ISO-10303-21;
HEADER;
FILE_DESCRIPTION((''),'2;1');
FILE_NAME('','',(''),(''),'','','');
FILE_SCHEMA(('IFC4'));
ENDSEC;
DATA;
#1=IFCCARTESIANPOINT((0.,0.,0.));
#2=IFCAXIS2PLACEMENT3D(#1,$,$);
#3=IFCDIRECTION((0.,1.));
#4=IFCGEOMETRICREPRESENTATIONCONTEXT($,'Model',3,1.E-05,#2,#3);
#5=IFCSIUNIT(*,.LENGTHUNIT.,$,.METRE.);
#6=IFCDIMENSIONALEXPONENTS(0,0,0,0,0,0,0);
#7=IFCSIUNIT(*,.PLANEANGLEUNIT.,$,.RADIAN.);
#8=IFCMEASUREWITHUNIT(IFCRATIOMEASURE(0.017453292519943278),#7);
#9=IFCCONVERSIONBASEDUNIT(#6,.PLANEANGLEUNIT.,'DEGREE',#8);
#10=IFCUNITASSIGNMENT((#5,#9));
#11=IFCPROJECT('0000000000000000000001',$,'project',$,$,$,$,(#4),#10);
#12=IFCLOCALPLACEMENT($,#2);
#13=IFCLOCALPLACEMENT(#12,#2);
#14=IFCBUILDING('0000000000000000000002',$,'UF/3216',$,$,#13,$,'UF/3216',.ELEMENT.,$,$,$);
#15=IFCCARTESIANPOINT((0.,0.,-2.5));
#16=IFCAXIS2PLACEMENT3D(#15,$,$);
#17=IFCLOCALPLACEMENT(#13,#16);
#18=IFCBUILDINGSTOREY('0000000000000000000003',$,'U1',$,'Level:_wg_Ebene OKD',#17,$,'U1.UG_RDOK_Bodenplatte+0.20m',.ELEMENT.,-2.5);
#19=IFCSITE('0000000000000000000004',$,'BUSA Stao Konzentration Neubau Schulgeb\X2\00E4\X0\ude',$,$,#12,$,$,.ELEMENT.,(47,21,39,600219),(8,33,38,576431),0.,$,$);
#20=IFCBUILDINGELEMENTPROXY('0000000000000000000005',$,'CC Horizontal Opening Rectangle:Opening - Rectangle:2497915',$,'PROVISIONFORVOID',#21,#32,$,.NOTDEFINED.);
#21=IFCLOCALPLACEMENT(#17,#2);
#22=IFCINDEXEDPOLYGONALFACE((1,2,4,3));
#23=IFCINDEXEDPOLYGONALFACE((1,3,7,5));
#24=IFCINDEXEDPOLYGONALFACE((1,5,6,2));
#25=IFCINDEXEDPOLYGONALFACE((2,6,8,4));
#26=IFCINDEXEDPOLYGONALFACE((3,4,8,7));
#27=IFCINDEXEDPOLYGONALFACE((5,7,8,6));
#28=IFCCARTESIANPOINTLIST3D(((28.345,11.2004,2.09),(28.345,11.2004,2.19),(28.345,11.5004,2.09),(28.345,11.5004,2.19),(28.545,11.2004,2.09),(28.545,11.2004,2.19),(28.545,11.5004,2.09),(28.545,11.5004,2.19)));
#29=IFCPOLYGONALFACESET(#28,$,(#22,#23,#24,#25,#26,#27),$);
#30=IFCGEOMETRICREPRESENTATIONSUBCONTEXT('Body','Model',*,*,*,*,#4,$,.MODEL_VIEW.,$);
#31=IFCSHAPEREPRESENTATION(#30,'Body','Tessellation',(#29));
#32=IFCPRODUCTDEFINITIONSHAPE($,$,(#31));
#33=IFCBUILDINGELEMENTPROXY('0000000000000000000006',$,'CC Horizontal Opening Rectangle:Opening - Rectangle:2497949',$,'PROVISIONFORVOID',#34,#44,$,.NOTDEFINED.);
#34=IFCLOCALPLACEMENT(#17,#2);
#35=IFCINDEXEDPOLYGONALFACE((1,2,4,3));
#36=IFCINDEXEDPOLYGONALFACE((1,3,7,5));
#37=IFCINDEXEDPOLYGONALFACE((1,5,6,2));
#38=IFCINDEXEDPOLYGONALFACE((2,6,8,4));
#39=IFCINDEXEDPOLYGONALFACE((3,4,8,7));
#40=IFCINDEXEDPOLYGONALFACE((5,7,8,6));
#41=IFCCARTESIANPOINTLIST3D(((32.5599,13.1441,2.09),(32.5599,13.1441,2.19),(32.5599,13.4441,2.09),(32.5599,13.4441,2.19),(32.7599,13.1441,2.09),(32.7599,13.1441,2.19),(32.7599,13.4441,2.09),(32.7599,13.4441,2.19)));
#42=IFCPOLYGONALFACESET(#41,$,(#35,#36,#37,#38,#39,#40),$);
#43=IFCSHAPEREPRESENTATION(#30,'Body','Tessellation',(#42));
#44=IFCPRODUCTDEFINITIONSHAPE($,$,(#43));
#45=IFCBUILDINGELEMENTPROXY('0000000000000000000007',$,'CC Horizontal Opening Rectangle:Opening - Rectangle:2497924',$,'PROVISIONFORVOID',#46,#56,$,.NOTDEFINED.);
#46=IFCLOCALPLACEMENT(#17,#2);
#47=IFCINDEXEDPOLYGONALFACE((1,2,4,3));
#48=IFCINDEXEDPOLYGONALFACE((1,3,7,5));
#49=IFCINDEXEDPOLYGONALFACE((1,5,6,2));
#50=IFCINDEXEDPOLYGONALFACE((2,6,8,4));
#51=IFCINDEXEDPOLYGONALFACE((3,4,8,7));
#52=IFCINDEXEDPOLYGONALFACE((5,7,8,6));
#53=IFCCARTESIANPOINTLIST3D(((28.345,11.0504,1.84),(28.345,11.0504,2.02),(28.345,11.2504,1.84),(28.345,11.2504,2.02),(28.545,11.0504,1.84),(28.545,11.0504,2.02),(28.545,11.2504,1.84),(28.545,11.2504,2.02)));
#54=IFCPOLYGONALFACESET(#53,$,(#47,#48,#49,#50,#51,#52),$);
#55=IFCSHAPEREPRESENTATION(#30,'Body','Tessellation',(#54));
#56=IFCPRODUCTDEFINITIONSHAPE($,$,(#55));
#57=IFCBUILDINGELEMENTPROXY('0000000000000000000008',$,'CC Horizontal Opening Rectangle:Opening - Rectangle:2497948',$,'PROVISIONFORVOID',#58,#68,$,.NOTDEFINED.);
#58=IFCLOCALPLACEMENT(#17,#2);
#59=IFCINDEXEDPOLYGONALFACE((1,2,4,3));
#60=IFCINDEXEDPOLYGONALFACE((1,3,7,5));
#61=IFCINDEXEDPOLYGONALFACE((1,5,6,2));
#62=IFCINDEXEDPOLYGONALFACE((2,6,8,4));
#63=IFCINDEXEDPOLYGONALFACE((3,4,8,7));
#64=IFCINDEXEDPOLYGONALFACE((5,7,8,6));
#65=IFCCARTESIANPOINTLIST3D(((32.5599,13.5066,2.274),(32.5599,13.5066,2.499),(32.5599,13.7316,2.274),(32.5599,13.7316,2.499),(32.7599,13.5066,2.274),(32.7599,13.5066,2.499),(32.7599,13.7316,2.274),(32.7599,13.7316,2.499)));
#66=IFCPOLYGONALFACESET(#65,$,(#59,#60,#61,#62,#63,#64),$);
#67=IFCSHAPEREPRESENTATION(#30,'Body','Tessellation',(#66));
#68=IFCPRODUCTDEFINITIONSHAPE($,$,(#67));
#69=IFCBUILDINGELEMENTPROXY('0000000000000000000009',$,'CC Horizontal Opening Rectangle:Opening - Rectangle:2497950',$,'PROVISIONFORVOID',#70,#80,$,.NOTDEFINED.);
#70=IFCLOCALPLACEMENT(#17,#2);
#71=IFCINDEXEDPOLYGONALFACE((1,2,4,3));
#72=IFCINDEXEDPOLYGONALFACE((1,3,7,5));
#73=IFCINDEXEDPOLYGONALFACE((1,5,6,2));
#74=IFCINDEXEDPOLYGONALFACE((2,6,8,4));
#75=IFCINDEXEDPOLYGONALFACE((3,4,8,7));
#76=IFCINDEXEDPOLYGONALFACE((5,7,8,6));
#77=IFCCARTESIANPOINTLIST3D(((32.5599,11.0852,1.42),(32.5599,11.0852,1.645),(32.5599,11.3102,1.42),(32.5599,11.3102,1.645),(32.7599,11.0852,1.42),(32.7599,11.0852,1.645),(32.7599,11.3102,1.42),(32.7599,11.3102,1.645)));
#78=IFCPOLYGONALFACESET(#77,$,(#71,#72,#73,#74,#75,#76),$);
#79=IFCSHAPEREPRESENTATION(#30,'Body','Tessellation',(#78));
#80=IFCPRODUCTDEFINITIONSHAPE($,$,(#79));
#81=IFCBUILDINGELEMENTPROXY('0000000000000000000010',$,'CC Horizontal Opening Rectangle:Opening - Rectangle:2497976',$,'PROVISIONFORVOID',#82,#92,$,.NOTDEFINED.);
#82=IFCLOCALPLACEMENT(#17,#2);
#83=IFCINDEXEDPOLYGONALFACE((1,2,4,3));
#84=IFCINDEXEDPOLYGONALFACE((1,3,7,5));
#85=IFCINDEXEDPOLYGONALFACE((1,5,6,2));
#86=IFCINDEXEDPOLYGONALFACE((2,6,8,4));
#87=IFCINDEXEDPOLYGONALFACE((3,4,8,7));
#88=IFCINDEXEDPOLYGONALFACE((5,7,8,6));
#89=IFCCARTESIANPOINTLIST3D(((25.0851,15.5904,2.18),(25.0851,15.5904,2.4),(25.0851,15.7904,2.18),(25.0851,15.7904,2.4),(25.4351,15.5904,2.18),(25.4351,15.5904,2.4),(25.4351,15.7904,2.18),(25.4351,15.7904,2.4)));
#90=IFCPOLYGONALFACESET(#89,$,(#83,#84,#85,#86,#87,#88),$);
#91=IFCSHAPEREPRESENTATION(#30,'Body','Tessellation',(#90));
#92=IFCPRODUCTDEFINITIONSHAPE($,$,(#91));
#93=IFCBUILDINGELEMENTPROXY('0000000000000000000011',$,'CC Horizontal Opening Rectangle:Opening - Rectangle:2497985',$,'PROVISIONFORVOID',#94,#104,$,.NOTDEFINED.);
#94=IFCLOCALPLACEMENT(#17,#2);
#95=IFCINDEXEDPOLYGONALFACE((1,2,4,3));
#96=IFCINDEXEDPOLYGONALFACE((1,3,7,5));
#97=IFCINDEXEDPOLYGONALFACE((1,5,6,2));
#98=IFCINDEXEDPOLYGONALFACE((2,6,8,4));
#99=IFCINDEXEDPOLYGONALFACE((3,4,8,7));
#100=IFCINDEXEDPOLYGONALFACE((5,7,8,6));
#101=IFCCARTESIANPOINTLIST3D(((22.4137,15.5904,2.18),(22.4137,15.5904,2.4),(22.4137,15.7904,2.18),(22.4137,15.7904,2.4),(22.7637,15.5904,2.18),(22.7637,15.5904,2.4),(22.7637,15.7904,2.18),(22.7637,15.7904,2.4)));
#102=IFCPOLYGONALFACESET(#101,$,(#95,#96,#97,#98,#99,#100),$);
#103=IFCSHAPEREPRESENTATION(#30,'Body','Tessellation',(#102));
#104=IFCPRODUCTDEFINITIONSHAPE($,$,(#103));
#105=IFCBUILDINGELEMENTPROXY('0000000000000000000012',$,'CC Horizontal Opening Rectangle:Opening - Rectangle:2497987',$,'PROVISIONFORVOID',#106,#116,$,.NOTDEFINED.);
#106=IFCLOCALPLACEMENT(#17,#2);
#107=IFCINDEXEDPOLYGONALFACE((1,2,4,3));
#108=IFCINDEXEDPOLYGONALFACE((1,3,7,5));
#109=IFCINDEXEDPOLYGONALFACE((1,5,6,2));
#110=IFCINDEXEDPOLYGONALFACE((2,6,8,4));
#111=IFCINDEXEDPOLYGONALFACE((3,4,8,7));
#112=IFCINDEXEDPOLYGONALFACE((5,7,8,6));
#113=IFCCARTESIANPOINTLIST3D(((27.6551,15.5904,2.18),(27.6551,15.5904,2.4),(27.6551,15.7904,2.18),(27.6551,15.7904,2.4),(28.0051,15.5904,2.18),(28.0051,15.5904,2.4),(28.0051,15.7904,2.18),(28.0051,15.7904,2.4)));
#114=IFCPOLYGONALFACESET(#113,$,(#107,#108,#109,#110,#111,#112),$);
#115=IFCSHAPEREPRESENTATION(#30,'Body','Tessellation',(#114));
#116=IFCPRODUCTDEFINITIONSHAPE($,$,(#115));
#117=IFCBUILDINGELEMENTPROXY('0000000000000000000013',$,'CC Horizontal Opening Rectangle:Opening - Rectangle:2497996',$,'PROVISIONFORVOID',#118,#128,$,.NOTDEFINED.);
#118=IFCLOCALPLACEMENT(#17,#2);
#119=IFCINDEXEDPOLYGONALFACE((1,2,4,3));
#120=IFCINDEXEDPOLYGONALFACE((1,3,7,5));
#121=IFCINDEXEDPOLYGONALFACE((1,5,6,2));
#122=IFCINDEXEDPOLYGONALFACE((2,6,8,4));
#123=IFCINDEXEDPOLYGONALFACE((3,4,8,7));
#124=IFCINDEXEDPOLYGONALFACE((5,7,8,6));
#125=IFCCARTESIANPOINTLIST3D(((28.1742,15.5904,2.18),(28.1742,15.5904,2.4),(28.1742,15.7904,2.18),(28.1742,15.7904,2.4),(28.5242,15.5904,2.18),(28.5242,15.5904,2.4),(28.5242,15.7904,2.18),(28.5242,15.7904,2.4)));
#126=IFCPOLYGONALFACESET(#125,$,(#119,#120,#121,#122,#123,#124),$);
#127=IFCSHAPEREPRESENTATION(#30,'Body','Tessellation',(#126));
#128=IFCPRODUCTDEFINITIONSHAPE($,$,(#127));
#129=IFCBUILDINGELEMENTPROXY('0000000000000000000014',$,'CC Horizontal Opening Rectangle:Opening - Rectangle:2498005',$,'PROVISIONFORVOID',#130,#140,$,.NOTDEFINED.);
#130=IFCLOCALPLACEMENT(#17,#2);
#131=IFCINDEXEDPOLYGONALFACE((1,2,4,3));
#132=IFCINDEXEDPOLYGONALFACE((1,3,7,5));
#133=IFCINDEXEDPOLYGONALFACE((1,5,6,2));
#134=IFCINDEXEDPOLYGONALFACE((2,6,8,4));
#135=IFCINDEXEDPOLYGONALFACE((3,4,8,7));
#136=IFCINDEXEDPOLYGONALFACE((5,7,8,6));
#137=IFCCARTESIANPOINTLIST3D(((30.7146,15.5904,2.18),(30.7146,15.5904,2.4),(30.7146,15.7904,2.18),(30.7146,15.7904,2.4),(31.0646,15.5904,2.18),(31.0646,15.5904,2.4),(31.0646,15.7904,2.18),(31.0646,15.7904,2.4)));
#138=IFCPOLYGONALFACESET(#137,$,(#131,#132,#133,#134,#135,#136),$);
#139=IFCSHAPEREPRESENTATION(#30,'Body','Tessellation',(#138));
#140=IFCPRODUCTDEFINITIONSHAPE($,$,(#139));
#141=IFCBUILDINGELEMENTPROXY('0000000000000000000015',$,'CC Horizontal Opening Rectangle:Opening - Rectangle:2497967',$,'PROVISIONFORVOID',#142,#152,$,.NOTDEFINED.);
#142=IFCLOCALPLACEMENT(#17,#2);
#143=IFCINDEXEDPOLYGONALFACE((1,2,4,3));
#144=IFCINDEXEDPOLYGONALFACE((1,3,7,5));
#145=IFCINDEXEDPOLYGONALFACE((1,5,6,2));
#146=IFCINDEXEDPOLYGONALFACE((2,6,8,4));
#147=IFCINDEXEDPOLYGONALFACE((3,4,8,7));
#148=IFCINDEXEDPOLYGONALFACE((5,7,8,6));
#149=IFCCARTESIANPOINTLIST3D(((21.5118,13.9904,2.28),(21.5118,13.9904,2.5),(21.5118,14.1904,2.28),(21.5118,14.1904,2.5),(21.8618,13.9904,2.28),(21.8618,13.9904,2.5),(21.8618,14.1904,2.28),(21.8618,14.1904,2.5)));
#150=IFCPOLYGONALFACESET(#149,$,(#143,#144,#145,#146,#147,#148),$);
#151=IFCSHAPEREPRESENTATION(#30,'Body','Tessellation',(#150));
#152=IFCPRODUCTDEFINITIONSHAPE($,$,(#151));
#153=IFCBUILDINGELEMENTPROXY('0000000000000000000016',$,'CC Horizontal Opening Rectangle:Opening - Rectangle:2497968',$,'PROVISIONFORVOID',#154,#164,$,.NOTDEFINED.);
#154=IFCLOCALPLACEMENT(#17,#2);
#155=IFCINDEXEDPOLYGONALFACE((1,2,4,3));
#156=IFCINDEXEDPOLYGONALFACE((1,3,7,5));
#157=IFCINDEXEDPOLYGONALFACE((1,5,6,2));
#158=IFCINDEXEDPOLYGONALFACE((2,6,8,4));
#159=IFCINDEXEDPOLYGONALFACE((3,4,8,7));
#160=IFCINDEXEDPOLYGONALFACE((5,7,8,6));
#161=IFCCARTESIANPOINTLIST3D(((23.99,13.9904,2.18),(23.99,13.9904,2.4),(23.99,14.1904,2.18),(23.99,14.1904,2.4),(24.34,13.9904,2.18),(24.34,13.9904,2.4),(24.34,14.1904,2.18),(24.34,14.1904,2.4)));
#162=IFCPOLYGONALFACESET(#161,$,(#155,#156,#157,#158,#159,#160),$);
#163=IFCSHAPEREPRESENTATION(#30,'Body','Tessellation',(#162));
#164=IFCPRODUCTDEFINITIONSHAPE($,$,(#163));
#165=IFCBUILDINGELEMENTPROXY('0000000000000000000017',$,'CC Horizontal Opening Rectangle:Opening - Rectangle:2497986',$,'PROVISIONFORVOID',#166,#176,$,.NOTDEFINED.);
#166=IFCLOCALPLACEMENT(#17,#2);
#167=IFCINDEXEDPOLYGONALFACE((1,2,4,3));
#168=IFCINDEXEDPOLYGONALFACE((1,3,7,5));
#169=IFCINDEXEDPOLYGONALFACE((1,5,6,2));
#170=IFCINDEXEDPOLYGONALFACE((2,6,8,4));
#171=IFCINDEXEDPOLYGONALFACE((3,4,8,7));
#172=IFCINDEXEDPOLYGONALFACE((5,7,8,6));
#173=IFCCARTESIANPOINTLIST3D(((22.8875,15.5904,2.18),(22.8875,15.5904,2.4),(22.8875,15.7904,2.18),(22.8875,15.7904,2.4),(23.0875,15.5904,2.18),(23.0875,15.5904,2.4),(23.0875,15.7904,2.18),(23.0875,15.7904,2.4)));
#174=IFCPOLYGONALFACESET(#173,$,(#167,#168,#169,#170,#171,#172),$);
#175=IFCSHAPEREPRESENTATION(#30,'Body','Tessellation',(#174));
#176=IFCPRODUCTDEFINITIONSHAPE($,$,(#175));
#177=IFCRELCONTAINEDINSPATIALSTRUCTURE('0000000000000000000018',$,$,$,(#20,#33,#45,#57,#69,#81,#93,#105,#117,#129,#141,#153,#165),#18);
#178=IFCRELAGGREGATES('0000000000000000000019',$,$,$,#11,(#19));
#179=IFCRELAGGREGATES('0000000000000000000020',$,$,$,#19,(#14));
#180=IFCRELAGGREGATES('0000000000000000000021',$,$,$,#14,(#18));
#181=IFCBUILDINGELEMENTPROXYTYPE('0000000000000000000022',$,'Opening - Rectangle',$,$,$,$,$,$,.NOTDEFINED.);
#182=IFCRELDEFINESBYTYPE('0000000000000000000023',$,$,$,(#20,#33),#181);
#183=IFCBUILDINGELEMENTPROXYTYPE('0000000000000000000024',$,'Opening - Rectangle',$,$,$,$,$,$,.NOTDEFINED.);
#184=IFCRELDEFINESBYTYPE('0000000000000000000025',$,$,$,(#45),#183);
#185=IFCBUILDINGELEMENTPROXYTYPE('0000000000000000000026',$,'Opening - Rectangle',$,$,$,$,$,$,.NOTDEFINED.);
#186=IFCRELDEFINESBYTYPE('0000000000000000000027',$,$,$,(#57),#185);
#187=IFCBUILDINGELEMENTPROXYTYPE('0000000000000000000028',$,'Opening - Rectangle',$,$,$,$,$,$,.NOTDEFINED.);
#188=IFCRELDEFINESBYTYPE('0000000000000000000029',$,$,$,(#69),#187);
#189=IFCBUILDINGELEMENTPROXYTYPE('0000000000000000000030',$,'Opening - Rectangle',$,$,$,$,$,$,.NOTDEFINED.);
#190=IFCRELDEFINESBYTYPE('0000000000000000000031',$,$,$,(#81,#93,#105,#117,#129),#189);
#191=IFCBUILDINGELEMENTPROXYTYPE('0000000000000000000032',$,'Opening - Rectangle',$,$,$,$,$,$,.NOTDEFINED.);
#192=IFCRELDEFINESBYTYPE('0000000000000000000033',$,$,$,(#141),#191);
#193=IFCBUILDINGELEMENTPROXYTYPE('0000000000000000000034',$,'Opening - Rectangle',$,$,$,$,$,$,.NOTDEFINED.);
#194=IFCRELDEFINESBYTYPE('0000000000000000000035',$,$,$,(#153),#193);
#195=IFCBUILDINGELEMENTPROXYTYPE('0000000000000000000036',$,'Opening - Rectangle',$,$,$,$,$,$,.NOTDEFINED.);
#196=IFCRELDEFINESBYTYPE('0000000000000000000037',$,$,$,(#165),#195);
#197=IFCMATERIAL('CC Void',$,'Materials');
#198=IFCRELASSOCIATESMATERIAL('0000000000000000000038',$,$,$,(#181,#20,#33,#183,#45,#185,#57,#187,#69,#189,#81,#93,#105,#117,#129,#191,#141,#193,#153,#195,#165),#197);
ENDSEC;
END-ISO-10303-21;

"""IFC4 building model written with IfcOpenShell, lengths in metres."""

from ifc_helpers import new_model, entity, si_unit, converted_unit, direction, frame, origin, place, context, subcontext, project, spatial, indexed_curve, outline, extrude, source, transform, mapped, material, type_object, type_shapes, element, save


model = new_model("IFC4")

# Units and contexts
model_context = context("Model", 3, precision=1e-05, world=origin(), true_north=direction((0.0, 1.0)))
body_context = subcontext(model_context, "Body", "Model", "MODEL_VIEW")
ifc_project = project(units=[si_unit("LENGTHUNIT", "METRE"), converted_unit("PLANEANGLEUNIT", "DEGREE", entity("IfcRatioMeasure", 0.017453292519943278), si_unit("PLANEANGLEUNIT", "RADIAN"), dimensions=[0, 0, 0, 0, 0, 0, 0])], contexts=[model_context])

# Site, building, storey
site_placement = place(None, origin())
site = spatial("IfcSite", under=ifc_project, at=site_placement, Name="BUSA Stao Konzentration Neubau Schulgebäude", CompositionType="ELEMENT", RefLatitude=(47, 21, 39, 600219), RefLongitude=(8, 33, 38, 576431), RefElevation=0.0)
building_placement = place(site_placement, origin())
building = spatial("IfcBuilding", under=site, at=building_placement, Name="UF/3216", LongName="UF/3216", CompositionType="ELEMENT")
storey_placement = place(building_placement, frame((0.0, 0.0, -2.5)))
storey = spatial("IfcBuildingStorey", under=building, at=storey_placement, Name="U1", ObjectType="Level:_wg_Ebene OKD", LongName="U1.UG_RDOK_Bodenplatte+0.20m", CompositionType="ELEMENT", Elevation=-2.5)

# Building element proxies
ifc_material_1 = material(Name="CC Void", Category="Materials")
building_element_proxy_type_1 = type_object("IfcBuildingElementProxyType", Name="Opening - Rectangle", PredefinedType="NOTDEFINED", material=ifc_material_1)
shared_shape_1 = source(origin(), body_context, "Body", "SweptSolid", [
    extrude(outline(indexed_curve([(-0.1, -0.15), (0.1, -0.15), (0.1, 0.15), (-0.1, 0.15), (-0.1, -0.15)], self_intersect=False)), frame((0.0, 0.0, -0.41), z_axis=(0.0, 0.0, 1.0), x_axis=(0.0, -1.0, 0.0)), (0.0, 0.0, 1.0), 0.1),
])
type_shapes(building_element_proxy_type_1, [shared_shape_1])
for number, where, z_axis, x_axis, name in (
    (1, (28.445, 11.3504, 2.5), (0.0, 0.0, 1.0), (0.0, 1.0, 0.0), "CC Horizontal Opening Rectangle:Opening - Rectangle:2497915"),
    (2, (32.6599, 13.2941, 2.5), (0.0, 0.0, 1.0), (0.0, 1.0, 0.0), "CC Horizontal Opening Rectangle:Opening - Rectangle:2497949"),
):
    element("IfcBuildingElementProxy", number, at=place(storey_placement, frame(where, z_axis=z_axis, x_axis=x_axis)), inside=storey, type_object=building_element_proxy_type_1, material=ifc_material_1, Name=name, ObjectType="PROVISIONFORVOID", PredefinedType="NOTDEFINED", context=body_context, shape_type="MappedRepresentation", body=[
        mapped(shared_shape_1, transform((0.0, 0.0, 0.0), scale=1.0)),
    ])
building_element_proxy_type_2 = type_object("IfcBuildingElementProxyType", Name="Opening - Rectangle", PredefinedType="NOTDEFINED", material=ifc_material_1)
shared_shape_2 = source(origin(), body_context, "Body", "SweptSolid", [
    extrude(outline(indexed_curve([(-0.1, -0.1), (0.1, -0.1), (0.1, 0.1), (-0.1, 0.1), (-0.1, -0.1)], self_intersect=False)), frame((0.0, 0.0, -0.66), z_axis=(0.0, 0.0, 1.0), x_axis=(0.0, -1.0, 0.0)), (0.0, 0.0, 1.0), 0.18),
])
type_shapes(building_element_proxy_type_2, [shared_shape_2])
proxy_1_placement = place(storey_placement, frame((28.445, 11.1504, 2.5), z_axis=(0.0, 0.0, 1.0), x_axis=(0.0, 1.0, 0.0)))
element("IfcBuildingElementProxy", 3, at=proxy_1_placement, inside=storey, type_object=building_element_proxy_type_2, material=ifc_material_1, Name="CC Horizontal Opening Rectangle:Opening - Rectangle:2497924", ObjectType="PROVISIONFORVOID", PredefinedType="NOTDEFINED", context=body_context, shape_type="MappedRepresentation", body=[
    mapped(shared_shape_2, transform((0.0, 0.0, 0.0), scale=1.0)),
])
building_element_proxy_type_3 = type_object("IfcBuildingElementProxyType", Name="Opening - Rectangle", PredefinedType="NOTDEFINED", material=ifc_material_1)
shared_shape_3 = source(origin(), body_context, "Body", "SweptSolid", [
    extrude(outline(indexed_curve([(-0.1, -0.1125), (0.1, -0.1125), (0.1, 0.1125), (-0.1, 0.1125), (-0.1, -0.1125)], self_intersect=False)), frame((0.0, 0.0, -0.226), z_axis=(0.0, 0.0, 1.0), x_axis=(0.0, -1.0, 0.0)), (0.0, 0.0, 1.0), 0.225),
])
type_shapes(building_element_proxy_type_3, [shared_shape_3])
proxy_2_placement = place(storey_placement, frame((32.6599, 13.6191, 2.5), z_axis=(0.0, 0.0, 1.0), x_axis=(0.0, 1.0, 0.0)))
element("IfcBuildingElementProxy", 4, at=proxy_2_placement, inside=storey, type_object=building_element_proxy_type_3, material=ifc_material_1, Name="CC Horizontal Opening Rectangle:Opening - Rectangle:2497948", ObjectType="PROVISIONFORVOID", PredefinedType="NOTDEFINED", context=body_context, shape_type="MappedRepresentation", body=[
    mapped(shared_shape_3, transform((0.0, 0.0, 0.0), scale=1.0)),
])
building_element_proxy_type_4 = type_object("IfcBuildingElementProxyType", Name="Opening - Rectangle", PredefinedType="NOTDEFINED", material=ifc_material_1)
shared_shape_4 = source(origin(), body_context, "Body", "SweptSolid", [
    extrude(outline(indexed_curve([(-0.1, -0.1125), (0.1, -0.1125), (0.1, 0.1125), (-0.1, 0.1125), (-0.1, -0.1125)], self_intersect=False)), frame((0.0, 0.0, -1.08), z_axis=(0.0, 0.0, 1.0), x_axis=(0.0, -1.0, 0.0)), (0.0, 0.0, 1.0), 0.225),
])
type_shapes(building_element_proxy_type_4, [shared_shape_4])
proxy_3_placement = place(storey_placement, frame((32.6599, 11.1977, 2.5), z_axis=(0.0, 0.0, 1.0), x_axis=(0.0, 1.0, 0.0)))
element("IfcBuildingElementProxy", 5, at=proxy_3_placement, inside=storey, type_object=building_element_proxy_type_4, material=ifc_material_1, Name="CC Horizontal Opening Rectangle:Opening - Rectangle:2497950", ObjectType="PROVISIONFORVOID", PredefinedType="NOTDEFINED", context=body_context, shape_type="MappedRepresentation", body=[
    mapped(shared_shape_4, transform((0.0, 0.0, 0.0), scale=1.0)),
])
building_element_proxy_type_5 = type_object("IfcBuildingElementProxyType", Name="Opening - Rectangle", PredefinedType="NOTDEFINED", material=ifc_material_1)
shared_shape_5 = source(origin(), body_context, "Body", "SweptSolid", [
    extrude(outline(indexed_curve([(-0.1, -0.175), (0.1, -0.175), (0.1, 0.175), (-0.1, 0.175), (-0.1, -0.175)], self_intersect=False)), frame((0.0, 0.0, -0.32), z_axis=(0.0, 0.0, 1.0), x_axis=(0.0, -1.0, 0.0)), (0.0, 0.0, 1.0), 0.22),
])
type_shapes(building_element_proxy_type_5, [shared_shape_5])
for number, where, name in (
    (6, (25.2601, 15.6904, 2.5), "CC Horizontal Opening Rectangle:Opening - Rectangle:2497976"),
    (7, (22.5887, 15.6904, 2.5), "CC Horizontal Opening Rectangle:Opening - Rectangle:2497985"),
    (8, (27.8301, 15.6904, 2.5), "CC Horizontal Opening Rectangle:Opening - Rectangle:2497987"),
    (9, (28.3492, 15.6904, 2.5), "CC Horizontal Opening Rectangle:Opening - Rectangle:2497996"),
    (10, (30.8896, 15.6904, 2.5), "CC Horizontal Opening Rectangle:Opening - Rectangle:2498005"),
):
    element("IfcBuildingElementProxy", number, at=place(storey_placement, frame(where)), inside=storey, type_object=building_element_proxy_type_5, material=ifc_material_1, Name=name, ObjectType="PROVISIONFORVOID", PredefinedType="NOTDEFINED", context=body_context, shape_type="MappedRepresentation", body=[
        mapped(shared_shape_5, transform((0.0, 0.0, 0.0), scale=1.0)),
    ])
building_element_proxy_type_6 = type_object("IfcBuildingElementProxyType", Name="Opening - Rectangle", PredefinedType="NOTDEFINED", material=ifc_material_1)
shared_shape_6 = source(origin(), body_context, "Body", "SweptSolid", [
    extrude(outline(indexed_curve([(-0.1, -0.175), (0.1, -0.175), (0.1, 0.175), (-0.1, 0.175), (-0.1, -0.175)], self_intersect=False)), frame((0.0, 0.0, -0.22), z_axis=(0.0, 0.0, 1.0), x_axis=(0.0, -1.0, 0.0)), (0.0, 0.0, 1.0), 0.22),
])
type_shapes(building_element_proxy_type_6, [shared_shape_6])
proxy_4_placement = place(storey_placement, frame((21.6868, 14.0904, 2.5)))
element("IfcBuildingElementProxy", 11, at=proxy_4_placement, inside=storey, type_object=building_element_proxy_type_6, material=ifc_material_1, Name="CC Horizontal Opening Rectangle:Opening - Rectangle:2497967", ObjectType="PROVISIONFORVOID", PredefinedType="NOTDEFINED", context=body_context, shape_type="MappedRepresentation", body=[
    mapped(shared_shape_6, transform((0.0, 0.0, 0.0), scale=1.0)),
])
building_element_proxy_type_7 = type_object("IfcBuildingElementProxyType", Name="Opening - Rectangle", PredefinedType="NOTDEFINED", material=ifc_material_1)
shared_shape_7 = source(origin(), body_context, "Body", "SweptSolid", [
    extrude(outline(indexed_curve([(-0.1, -0.175), (0.1, -0.175), (0.1, 0.175), (-0.1, 0.175), (-0.1, -0.175)], self_intersect=False)), frame((0.0, 0.0, -0.32), z_axis=(0.0, 0.0, 1.0), x_axis=(0.0, -1.0, 0.0)), (0.0, 0.0, 1.0), 0.22),
])
type_shapes(building_element_proxy_type_7, [shared_shape_7])
proxy_5_placement = place(storey_placement, frame((24.165, 14.0904, 2.5)))
element("IfcBuildingElementProxy", 12, at=proxy_5_placement, inside=storey, type_object=building_element_proxy_type_7, material=ifc_material_1, Name="CC Horizontal Opening Rectangle:Opening - Rectangle:2497968", ObjectType="PROVISIONFORVOID", PredefinedType="NOTDEFINED", context=body_context, shape_type="MappedRepresentation", body=[
    mapped(shared_shape_7, transform((0.0, 0.0, 0.0), scale=1.0)),
])
building_element_proxy_type_8 = type_object("IfcBuildingElementProxyType", Name="Opening - Rectangle", PredefinedType="NOTDEFINED", material=ifc_material_1)
shared_shape_8 = source(origin(), body_context, "Body", "SweptSolid", [
    extrude(outline(indexed_curve([(-0.1, -0.1), (0.1, -0.1), (0.1, 0.1), (-0.1, 0.1), (-0.1, -0.1)], self_intersect=False)), frame((0.0, 0.0, -0.32), z_axis=(0.0, 0.0, 1.0), x_axis=(0.0, -1.0, 0.0)), (0.0, 0.0, 1.0), 0.22),
])
type_shapes(building_element_proxy_type_8, [shared_shape_8])
proxy_6_placement = place(storey_placement, frame((22.9875, 15.6904, 2.5)))
element("IfcBuildingElementProxy", 13, at=proxy_6_placement, inside=storey, type_object=building_element_proxy_type_8, material=ifc_material_1, Name="CC Horizontal Opening Rectangle:Opening - Rectangle:2497986", ObjectType="PROVISIONFORVOID", PredefinedType="NOTDEFINED", context=body_context, shape_type="MappedRepresentation", body=[
    mapped(shared_shape_8, transform((0.0, 0.0, 0.0), scale=1.0)),
])

save(model, "model.ifc")
